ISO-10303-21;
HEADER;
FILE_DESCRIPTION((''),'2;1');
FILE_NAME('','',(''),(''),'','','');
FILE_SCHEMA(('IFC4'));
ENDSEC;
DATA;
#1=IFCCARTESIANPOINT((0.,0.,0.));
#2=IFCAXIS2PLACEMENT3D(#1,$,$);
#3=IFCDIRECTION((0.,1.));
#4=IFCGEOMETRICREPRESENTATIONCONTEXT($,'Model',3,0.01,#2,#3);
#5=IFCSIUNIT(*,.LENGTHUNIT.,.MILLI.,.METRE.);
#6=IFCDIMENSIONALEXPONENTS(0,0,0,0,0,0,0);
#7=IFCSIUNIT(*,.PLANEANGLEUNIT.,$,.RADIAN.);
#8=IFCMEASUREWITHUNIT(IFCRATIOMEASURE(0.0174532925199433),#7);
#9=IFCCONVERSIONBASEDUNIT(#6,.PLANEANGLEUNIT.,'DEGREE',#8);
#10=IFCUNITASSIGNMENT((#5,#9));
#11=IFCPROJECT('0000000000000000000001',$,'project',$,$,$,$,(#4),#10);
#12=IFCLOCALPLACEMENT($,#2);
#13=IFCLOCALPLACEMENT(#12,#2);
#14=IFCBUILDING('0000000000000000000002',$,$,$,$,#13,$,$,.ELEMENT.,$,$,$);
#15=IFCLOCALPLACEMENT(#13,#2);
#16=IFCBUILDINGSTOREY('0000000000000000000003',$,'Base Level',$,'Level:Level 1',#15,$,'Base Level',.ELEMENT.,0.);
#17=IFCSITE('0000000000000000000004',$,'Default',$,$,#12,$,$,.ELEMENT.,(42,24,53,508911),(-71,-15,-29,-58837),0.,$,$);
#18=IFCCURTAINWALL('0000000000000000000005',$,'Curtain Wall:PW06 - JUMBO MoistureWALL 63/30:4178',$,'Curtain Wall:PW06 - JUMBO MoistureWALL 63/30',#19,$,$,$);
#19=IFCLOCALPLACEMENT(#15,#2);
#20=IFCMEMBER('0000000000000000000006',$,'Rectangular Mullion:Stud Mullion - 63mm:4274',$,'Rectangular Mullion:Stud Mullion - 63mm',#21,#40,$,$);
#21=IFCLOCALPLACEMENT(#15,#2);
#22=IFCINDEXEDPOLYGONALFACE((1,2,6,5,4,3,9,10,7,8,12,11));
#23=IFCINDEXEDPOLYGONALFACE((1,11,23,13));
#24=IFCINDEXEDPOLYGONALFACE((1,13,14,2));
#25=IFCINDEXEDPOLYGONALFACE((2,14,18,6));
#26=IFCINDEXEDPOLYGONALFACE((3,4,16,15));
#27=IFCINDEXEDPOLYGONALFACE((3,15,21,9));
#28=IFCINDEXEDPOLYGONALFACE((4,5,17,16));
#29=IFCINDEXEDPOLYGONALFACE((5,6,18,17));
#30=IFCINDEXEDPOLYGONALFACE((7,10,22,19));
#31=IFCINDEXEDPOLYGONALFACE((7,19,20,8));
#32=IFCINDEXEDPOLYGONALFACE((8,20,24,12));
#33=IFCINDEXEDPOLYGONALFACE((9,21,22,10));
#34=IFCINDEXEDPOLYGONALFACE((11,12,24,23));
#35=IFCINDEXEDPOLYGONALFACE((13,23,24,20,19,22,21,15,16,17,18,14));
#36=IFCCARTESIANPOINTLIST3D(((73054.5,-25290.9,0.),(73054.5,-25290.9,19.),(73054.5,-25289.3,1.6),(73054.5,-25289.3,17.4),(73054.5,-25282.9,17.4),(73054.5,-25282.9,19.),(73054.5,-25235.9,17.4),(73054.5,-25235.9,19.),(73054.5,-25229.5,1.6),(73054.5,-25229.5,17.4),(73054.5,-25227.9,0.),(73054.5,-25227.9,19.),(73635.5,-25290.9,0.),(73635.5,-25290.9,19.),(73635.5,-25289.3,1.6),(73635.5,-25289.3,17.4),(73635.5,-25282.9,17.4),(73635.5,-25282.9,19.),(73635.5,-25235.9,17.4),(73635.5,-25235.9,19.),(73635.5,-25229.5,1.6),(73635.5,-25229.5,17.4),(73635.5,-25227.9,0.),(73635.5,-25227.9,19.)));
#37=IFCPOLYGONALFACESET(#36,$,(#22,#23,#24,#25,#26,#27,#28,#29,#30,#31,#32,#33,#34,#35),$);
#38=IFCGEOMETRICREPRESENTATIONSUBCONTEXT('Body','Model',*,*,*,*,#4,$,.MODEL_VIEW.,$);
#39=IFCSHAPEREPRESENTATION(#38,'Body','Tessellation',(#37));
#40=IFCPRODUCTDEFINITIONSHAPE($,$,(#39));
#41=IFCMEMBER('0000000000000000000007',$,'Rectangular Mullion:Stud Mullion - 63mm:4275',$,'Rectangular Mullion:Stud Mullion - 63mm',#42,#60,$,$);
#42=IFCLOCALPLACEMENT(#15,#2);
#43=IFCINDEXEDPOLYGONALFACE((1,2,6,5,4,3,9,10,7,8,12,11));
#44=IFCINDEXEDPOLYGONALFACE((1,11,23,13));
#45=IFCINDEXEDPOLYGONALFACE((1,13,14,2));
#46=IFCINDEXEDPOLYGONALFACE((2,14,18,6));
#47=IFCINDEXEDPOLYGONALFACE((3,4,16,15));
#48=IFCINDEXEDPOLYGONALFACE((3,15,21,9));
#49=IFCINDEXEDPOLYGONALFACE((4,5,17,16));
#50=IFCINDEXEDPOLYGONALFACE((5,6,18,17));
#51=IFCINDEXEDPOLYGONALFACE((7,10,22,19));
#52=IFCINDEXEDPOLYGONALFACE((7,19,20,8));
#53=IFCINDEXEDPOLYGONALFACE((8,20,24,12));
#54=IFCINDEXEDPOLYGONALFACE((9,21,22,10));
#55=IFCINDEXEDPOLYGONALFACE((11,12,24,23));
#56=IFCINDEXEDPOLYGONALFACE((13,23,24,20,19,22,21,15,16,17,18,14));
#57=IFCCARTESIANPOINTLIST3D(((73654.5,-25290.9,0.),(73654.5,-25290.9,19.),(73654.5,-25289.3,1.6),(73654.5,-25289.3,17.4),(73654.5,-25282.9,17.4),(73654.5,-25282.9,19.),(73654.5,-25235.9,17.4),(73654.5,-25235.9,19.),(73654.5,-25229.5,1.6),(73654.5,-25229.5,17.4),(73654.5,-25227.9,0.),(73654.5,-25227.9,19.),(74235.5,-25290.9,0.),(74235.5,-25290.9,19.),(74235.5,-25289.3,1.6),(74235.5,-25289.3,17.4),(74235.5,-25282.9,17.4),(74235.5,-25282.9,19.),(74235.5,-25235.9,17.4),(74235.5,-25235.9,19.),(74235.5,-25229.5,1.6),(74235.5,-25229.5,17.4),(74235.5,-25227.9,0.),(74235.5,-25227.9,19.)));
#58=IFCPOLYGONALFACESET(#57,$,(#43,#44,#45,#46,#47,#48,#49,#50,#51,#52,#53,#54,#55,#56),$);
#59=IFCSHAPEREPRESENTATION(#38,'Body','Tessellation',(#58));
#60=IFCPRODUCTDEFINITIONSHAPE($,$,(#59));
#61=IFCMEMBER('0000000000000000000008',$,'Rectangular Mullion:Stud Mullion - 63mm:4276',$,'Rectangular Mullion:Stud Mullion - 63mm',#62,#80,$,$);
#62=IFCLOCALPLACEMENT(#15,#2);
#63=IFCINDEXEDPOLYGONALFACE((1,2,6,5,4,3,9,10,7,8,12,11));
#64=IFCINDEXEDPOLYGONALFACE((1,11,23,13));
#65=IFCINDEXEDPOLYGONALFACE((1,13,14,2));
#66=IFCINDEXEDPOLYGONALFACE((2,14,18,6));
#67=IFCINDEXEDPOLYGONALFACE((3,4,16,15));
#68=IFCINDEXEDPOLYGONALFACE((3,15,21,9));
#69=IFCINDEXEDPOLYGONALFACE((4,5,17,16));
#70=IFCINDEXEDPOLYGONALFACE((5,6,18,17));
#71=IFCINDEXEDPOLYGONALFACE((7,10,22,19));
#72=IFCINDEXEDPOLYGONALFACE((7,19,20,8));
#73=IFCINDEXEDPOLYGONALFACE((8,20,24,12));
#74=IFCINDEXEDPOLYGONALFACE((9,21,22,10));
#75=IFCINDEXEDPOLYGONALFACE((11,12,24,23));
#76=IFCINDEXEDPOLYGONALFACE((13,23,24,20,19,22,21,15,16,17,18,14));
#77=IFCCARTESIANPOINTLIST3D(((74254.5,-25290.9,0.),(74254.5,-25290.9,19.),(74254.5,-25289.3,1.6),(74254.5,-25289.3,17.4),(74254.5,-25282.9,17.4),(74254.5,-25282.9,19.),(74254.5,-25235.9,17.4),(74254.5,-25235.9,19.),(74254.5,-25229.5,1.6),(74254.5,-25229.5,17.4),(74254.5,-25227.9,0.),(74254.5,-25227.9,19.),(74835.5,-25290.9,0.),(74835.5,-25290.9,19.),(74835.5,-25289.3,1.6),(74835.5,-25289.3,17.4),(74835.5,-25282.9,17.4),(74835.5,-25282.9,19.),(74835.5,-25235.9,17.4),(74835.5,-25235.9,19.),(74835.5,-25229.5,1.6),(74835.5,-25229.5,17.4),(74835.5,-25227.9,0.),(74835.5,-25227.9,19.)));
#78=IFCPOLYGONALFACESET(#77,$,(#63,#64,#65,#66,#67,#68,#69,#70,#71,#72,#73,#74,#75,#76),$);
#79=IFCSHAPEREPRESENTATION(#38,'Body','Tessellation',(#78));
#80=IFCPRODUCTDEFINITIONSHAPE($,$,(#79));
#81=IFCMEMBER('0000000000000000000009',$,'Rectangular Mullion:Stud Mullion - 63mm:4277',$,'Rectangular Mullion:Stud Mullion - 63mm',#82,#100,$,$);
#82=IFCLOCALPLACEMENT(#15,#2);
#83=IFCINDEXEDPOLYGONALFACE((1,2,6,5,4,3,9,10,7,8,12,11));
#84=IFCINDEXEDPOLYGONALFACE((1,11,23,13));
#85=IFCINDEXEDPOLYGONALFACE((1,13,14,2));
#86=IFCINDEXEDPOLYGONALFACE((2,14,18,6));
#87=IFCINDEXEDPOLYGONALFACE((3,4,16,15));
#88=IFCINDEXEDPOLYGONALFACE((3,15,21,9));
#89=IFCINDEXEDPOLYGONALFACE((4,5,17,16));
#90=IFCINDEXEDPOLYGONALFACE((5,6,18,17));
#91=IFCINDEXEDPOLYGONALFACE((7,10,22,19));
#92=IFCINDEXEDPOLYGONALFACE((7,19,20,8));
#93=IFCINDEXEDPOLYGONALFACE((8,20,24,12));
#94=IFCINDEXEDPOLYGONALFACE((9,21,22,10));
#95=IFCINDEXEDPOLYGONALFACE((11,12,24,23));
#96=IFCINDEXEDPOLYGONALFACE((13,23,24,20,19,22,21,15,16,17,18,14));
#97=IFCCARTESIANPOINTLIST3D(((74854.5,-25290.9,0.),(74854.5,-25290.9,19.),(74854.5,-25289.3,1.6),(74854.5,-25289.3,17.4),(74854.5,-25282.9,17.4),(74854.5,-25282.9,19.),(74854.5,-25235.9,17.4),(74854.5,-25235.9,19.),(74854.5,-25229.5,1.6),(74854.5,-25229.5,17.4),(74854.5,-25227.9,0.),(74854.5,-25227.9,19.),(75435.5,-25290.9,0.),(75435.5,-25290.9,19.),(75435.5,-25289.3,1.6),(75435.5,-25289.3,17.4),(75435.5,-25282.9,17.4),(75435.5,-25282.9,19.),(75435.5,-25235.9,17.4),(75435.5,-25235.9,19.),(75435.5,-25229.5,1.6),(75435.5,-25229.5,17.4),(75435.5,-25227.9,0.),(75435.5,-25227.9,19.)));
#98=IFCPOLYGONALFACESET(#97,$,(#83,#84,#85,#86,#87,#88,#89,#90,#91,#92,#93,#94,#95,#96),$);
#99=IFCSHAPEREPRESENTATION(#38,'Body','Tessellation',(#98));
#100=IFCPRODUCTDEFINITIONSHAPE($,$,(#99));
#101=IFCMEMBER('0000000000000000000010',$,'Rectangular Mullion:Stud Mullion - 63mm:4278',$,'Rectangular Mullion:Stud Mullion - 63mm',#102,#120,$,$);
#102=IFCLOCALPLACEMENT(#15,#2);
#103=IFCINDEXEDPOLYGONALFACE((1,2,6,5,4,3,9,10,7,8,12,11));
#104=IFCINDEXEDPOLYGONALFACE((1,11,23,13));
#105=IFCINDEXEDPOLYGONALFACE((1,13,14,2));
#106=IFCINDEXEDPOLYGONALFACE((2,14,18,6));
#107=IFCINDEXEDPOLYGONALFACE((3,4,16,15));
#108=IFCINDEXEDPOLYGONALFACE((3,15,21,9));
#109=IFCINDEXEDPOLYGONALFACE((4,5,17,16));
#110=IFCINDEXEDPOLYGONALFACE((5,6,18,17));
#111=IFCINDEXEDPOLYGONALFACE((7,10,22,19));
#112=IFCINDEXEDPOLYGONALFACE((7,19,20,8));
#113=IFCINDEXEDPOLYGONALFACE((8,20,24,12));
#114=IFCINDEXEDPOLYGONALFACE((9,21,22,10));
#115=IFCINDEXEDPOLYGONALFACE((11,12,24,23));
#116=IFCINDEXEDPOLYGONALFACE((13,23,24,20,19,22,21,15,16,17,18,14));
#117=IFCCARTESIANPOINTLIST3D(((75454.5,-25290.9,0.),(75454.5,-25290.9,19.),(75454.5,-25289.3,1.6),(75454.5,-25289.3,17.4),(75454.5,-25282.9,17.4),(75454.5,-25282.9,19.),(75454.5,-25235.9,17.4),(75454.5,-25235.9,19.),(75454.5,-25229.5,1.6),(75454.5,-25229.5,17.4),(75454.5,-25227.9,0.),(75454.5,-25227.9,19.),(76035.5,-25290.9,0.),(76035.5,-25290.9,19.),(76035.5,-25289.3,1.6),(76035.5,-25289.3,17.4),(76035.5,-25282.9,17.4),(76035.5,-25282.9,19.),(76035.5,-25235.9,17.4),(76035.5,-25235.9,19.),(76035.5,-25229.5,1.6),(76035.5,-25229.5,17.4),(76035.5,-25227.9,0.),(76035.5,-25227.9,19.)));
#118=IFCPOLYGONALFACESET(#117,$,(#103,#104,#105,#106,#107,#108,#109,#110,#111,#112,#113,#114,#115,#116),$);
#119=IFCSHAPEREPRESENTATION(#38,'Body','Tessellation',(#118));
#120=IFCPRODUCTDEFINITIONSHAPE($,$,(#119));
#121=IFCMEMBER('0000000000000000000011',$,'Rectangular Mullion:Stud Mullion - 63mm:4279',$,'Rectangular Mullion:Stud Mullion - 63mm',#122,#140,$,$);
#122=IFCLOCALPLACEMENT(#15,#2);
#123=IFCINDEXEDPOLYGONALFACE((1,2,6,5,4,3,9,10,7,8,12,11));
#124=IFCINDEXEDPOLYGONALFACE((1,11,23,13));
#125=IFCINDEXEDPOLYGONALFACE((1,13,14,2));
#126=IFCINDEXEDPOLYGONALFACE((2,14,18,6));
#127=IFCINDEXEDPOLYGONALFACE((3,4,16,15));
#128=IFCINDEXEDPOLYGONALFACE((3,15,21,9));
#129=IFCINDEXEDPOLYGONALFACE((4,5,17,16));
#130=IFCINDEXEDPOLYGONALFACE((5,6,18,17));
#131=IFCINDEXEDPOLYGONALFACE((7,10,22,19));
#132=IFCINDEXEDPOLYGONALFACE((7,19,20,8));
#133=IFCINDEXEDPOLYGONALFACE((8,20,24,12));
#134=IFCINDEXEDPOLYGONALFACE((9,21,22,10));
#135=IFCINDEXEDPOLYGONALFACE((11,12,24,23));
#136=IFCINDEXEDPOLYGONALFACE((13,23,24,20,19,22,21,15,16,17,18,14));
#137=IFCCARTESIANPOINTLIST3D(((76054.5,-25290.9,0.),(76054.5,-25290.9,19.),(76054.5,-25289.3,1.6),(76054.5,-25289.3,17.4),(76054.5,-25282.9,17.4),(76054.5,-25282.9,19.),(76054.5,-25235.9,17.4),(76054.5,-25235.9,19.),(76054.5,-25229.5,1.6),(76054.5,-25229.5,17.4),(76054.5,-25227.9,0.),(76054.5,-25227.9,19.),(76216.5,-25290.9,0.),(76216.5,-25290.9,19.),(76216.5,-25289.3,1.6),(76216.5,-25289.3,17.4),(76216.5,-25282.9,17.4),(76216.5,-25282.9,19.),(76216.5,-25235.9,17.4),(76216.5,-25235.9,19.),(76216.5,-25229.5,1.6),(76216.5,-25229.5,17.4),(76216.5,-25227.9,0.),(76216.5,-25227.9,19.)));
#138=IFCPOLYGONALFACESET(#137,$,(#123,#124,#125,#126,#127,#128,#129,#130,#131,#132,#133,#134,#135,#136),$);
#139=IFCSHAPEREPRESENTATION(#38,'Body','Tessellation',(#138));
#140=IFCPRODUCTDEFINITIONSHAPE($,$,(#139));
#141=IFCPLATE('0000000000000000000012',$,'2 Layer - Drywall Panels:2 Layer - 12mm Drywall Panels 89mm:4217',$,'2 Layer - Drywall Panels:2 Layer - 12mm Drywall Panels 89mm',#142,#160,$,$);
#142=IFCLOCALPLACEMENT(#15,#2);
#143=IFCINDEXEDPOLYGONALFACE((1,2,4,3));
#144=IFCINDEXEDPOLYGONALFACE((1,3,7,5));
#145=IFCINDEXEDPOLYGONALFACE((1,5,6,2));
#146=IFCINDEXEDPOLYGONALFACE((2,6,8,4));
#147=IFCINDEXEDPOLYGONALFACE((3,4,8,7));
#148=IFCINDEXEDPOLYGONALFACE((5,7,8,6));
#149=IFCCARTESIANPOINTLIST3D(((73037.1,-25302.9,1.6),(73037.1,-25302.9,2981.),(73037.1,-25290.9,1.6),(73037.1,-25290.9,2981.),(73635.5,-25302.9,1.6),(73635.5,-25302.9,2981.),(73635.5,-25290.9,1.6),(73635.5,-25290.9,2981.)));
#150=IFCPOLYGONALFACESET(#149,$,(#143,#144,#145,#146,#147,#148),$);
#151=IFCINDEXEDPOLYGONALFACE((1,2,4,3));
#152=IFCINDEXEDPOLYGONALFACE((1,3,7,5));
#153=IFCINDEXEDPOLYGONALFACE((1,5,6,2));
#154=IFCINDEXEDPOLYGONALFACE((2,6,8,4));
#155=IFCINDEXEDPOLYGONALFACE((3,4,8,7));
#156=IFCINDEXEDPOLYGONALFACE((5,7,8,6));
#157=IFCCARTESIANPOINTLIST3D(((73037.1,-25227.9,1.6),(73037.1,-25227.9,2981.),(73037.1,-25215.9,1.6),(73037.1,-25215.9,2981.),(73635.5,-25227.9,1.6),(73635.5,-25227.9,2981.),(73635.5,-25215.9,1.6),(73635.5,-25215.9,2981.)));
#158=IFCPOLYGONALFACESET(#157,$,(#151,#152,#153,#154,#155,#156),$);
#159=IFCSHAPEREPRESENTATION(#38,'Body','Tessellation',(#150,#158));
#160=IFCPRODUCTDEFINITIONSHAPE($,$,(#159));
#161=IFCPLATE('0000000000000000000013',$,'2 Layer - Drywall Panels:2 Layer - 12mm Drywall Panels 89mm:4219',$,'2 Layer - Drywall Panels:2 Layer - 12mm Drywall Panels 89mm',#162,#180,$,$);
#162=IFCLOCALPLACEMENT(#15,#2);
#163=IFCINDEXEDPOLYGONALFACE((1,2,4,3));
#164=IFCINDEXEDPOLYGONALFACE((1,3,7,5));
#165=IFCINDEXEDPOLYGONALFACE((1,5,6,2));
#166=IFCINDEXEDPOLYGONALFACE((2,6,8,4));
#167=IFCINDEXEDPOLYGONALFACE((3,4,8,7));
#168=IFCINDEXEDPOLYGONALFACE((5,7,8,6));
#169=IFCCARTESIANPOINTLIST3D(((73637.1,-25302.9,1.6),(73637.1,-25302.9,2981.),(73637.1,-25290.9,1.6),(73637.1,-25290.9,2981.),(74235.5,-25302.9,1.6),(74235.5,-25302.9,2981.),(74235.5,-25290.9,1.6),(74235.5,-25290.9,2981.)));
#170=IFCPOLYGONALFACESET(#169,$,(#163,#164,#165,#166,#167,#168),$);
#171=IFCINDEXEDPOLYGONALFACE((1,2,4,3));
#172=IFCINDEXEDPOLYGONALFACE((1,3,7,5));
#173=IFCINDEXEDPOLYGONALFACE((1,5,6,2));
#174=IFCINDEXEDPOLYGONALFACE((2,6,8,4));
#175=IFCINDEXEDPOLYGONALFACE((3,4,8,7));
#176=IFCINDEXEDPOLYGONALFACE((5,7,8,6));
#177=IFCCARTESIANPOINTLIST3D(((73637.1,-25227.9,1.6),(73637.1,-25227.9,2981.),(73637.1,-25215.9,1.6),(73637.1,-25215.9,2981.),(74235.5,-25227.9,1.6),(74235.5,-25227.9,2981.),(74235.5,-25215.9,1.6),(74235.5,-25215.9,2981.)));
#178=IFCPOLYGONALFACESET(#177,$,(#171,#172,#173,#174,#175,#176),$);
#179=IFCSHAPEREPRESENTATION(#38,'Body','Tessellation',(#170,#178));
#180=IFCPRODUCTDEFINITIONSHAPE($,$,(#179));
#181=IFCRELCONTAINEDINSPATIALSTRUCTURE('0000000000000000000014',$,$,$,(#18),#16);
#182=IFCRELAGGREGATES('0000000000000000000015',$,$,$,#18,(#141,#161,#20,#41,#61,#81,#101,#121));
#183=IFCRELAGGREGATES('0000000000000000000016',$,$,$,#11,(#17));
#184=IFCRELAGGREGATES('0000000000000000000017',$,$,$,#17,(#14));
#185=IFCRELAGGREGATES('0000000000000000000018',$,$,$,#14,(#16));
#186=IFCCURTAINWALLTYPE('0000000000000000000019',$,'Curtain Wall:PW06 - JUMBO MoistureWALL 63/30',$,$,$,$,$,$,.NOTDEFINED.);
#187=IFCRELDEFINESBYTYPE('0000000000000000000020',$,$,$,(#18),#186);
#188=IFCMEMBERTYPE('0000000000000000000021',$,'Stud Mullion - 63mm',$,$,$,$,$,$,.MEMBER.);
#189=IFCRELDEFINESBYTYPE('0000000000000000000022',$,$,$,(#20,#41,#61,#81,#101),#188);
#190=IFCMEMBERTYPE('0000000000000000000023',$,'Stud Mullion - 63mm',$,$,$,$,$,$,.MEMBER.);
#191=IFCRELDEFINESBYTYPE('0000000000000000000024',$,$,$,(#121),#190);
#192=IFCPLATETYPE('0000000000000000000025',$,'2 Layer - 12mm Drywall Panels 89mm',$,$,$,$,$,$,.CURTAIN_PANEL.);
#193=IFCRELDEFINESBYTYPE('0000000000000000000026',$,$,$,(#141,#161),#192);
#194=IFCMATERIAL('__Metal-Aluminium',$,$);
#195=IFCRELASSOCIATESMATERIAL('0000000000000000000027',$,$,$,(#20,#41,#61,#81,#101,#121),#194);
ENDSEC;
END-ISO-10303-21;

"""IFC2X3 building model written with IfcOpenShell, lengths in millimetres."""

from ifc_helpers import new_model, entity, si_unit, converted_unit, direction, frame, frame_2d, origin, place, context, subcontext, project, spatial, polyline, rectangle, outline, extrude, source, transform, mapped, material, type_object, type_shapes, element, aggregate, save


model = new_model("IFC2X3")

# Units and contexts
model_context = context("Model", 3, precision=0.01, world=origin(), true_north=direction((0.0, 1.0)))
body_context = subcontext(model_context, "Body", "Model", "MODEL_VIEW")
ifc_project = project(units=[si_unit("LENGTHUNIT", "METRE", prefix="MILLI"), converted_unit("PLANEANGLEUNIT", "DEGREE", entity("IfcRatioMeasure", 0.0174532925199433), si_unit("PLANEANGLEUNIT", "RADIAN"), dimensions=[0, 0, 0, 0, 0, 0, 0])], contexts=[model_context])

# Site, building, storey
site_placement = place(None, origin())
site = spatial("IfcSite", under=ifc_project, at=site_placement, Name="Default", CompositionType="ELEMENT", RefLatitude=(42, 24, 53, 508911), RefLongitude=(-71, -15, -29, -58837), RefElevation=0.0)
building_placement = place(site_placement, origin())
building = spatial("IfcBuilding", under=site, at=building_placement, CompositionType="ELEMENT")
storey_placement = place(building_placement, origin())
storey = spatial("IfcBuildingStorey", under=building, at=storey_placement, Name="Base Level", ObjectType="Level:Level 1", LongName="Base Level", CompositionType="ELEMENT", Elevation=0.0)

# Curtain wall, members, plates
curtain_wall_type = type_object("IfcCurtainWallType", Name="Curtain Wall:PW06 - JUMBO MoistureWALL 63/30", PredefinedType="NOTDEFINED")
curtain_wall_placement = place(building_placement, origin())
curtain_wall = element("IfcCurtainWall", 1, at=curtain_wall_placement, inside=storey, type_object=curtain_wall_type, Name="Curtain Wall:PW06 - JUMBO MoistureWALL 63/30:4178", ObjectType="Curtain Wall:PW06 - JUMBO MoistureWALL 63/30")
ifc_material = material(Name="__Metal-Aluminium")
member_type_1 = type_object("IfcMemberType", Name="Stud Mullion - 63mm", PredefinedType="MEMBER")
shared_shape_1 = source(origin(), body_context, "Body", "SweptSolid", [
    extrude(outline(polyline([(23.5, -6.6), (31.5, -6.6), (31.5, 12.4), (-31.5, 12.4), (-31.5, -6.6), (-23.5, -6.6), (-23.5, -5.0), (-29.9, -5.0), (-29.9, 10.8), (29.9, 10.8), (29.9, -5.0), (23.5, -5.0), (23.5, -6.6)])), frame((-12.4, 0.0, -581.0), z_axis=(0.0, 0.0, 1.0), x_axis=(0.0, -1.0, 0.0)), (0.0, 0.0, 1.0), 581.0),
])
type_shapes(member_type_1, [shared_shape_1])
member_1_placement = place(building_placement, frame((73054.5, -25259.4, 0.0), z_axis=(-1.0, 0.0, 0.0), x_axis=(0.0, 0.0, -1.0)))
member_1 = element("IfcMember", 2, at=member_1_placement, type_object=member_type_1, material=ifc_material, Name="Rectangular Mullion:Stud Mullion - 63mm:4274", ObjectType="Rectangular Mullion:Stud Mullion - 63mm", context=body_context, shape_type="MappedRepresentation", body=[
    mapped(shared_shape_1, transform((0.0, 0.0, 0.0), scale=1.0)),
])
member_2_placement = place(building_placement, frame((73654.5, -25259.4, 0.0), z_axis=(-1.0, 0.0, 0.0), x_axis=(0.0, 0.0, -1.0)))
member_2 = element("IfcMember", 3, at=member_2_placement, type_object=member_type_1, material=ifc_material, Name="Rectangular Mullion:Stud Mullion - 63mm:4275", ObjectType="Rectangular Mullion:Stud Mullion - 63mm", context=body_context, shape_type="MappedRepresentation", body=[
    mapped(shared_shape_1, transform((0.0, 0.0, 0.0), scale=1.0)),
])
member_3_placement = place(building_placement, frame((74254.5, -25259.4, 0.0), z_axis=(-1.0, 0.0, 0.0), x_axis=(0.0, 0.0, -1.0)))
member_3 = element("IfcMember", 4, at=member_3_placement, type_object=member_type_1, material=ifc_material, Name="Rectangular Mullion:Stud Mullion - 63mm:4276", ObjectType="Rectangular Mullion:Stud Mullion - 63mm", context=body_context, shape_type="MappedRepresentation", body=[
    mapped(shared_shape_1, transform((0.0, 0.0, 0.0), scale=1.0)),
])
member_4_placement = place(building_placement, frame((74854.5, -25259.4, 0.0), z_axis=(-1.0, 0.0, 0.0), x_axis=(0.0, 0.0, -1.0)))
member_4 = element("IfcMember", 5, at=member_4_placement, type_object=member_type_1, material=ifc_material, Name="Rectangular Mullion:Stud Mullion - 63mm:4277", ObjectType="Rectangular Mullion:Stud Mullion - 63mm", context=body_context, shape_type="MappedRepresentation", body=[
    mapped(shared_shape_1, transform((0.0, 0.0, 0.0), scale=1.0)),
])
member_5_placement = place(building_placement, frame((75454.5, -25259.4, 0.0), z_axis=(-1.0, 0.0, 0.0), x_axis=(0.0, 0.0, -1.0)))
member_5 = element("IfcMember", 6, at=member_5_placement, type_object=member_type_1, material=ifc_material, Name="Rectangular Mullion:Stud Mullion - 63mm:4278", ObjectType="Rectangular Mullion:Stud Mullion - 63mm", context=body_context, shape_type="MappedRepresentation", body=[
    mapped(shared_shape_1, transform((0.0, 0.0, 0.0), scale=1.0)),
])
member_type_2 = type_object("IfcMemberType", Name="Stud Mullion - 63mm", PredefinedType="MEMBER")
shared_shape_2 = source(origin(), body_context, "Body", "SweptSolid", [
    extrude(outline(polyline([(23.5, -6.6), (31.5, -6.6), (31.5, 12.4), (-31.5, 12.4), (-31.5, -6.6), (-23.5, -6.6), (-23.5, -5.0), (-29.9, -5.0), (-29.9, 10.8), (29.9, 10.8), (29.9, -5.0), (23.5, -5.0), (23.5, -6.6)])), frame((-12.4, 0.0, -162.0), z_axis=(0.0, 0.0, 1.0), x_axis=(0.0, -1.0, 0.0)), (0.0, 0.0, 1.0), 162.0),
])
type_shapes(member_type_2, [shared_shape_2])
member_6_placement = place(building_placement, frame((76054.5, -25259.4, 0.0), z_axis=(-1.0, 0.0, 0.0), x_axis=(0.0, 0.0, -1.0)))
member_6 = element("IfcMember", 7, at=member_6_placement, type_object=member_type_2, material=ifc_material, Name="Rectangular Mullion:Stud Mullion - 63mm:4279", ObjectType="Rectangular Mullion:Stud Mullion - 63mm", context=body_context, shape_type="MappedRepresentation", body=[
    mapped(shared_shape_2, transform((0.0, 0.0, 0.0), scale=1.0)),
])
plate_type_1 = type_object("IfcPlateType", Name="2 Layer - 12mm Drywall Panels 89mm", PredefinedType="CURTAIN_PANEL")
shared_shape_3 = source(origin(), body_context, "Body", "SweptSolid", [
    extrude(rectangle(XDim=598.4, YDim=12.0, at=frame_2d((0.0, 0.0), x_axis=(1.0, 0.0))), frame((0.0, -37.5, 0.0), z_axis=(0.0, 0.0, 1.0), x_axis=(-1.0, 0.0, 0.0)), (0.0, 0.0, 1.0), 2979.4),
    extrude(rectangle(XDim=12.0, YDim=598.4, at=frame_2d((0.0, 0.0), x_axis=(1.0, 0.0))), frame((0.0, 37.5, 0.0), z_axis=(0.0, 0.0, 1.0), x_axis=(0.0, 1.0, 0.0)), (0.0, 0.0, 1.0), 2979.4),
])
type_shapes(plate_type_1, [shared_shape_3])
plate_1_placement = place(curtain_wall_placement, frame((73336.3, -25259.4, 1.6)))
plate_1 = element("IfcPlate", 8, at=plate_1_placement, type_object=plate_type_1, Name="2 Layer - Drywall Panels:2 Layer - 12mm Drywall Panels 89mm:4217", ObjectType="2 Layer - Drywall Panels:2 Layer - 12mm Drywall Panels 89mm", context=body_context, shape_type="MappedRepresentation", body=[
    mapped(shared_shape_3, transform((0.0, 0.0, 0.0), scale=1.0)),
])
plate_2_placement = place(curtain_wall_placement, frame((73936.3, -25259.4, 1.6)))
plate_2 = element("IfcPlate", 9, at=plate_2_placement, type_object=plate_type_1, Name="2 Layer - Drywall Panels:2 Layer - 12mm Drywall Panels 89mm:4219", ObjectType="2 Layer - Drywall Panels:2 Layer - 12mm Drywall Panels 89mm", context=body_context, shape_type="MappedRepresentation", body=[
    mapped(shared_shape_3, transform((0.0, 0.0, 0.0), scale=1.0)),
])
aggregate(curtain_wall, [plate_1, plate_2, member_1, member_2, member_3, member_4, member_5, member_6])

save(model, "model.ifc")
